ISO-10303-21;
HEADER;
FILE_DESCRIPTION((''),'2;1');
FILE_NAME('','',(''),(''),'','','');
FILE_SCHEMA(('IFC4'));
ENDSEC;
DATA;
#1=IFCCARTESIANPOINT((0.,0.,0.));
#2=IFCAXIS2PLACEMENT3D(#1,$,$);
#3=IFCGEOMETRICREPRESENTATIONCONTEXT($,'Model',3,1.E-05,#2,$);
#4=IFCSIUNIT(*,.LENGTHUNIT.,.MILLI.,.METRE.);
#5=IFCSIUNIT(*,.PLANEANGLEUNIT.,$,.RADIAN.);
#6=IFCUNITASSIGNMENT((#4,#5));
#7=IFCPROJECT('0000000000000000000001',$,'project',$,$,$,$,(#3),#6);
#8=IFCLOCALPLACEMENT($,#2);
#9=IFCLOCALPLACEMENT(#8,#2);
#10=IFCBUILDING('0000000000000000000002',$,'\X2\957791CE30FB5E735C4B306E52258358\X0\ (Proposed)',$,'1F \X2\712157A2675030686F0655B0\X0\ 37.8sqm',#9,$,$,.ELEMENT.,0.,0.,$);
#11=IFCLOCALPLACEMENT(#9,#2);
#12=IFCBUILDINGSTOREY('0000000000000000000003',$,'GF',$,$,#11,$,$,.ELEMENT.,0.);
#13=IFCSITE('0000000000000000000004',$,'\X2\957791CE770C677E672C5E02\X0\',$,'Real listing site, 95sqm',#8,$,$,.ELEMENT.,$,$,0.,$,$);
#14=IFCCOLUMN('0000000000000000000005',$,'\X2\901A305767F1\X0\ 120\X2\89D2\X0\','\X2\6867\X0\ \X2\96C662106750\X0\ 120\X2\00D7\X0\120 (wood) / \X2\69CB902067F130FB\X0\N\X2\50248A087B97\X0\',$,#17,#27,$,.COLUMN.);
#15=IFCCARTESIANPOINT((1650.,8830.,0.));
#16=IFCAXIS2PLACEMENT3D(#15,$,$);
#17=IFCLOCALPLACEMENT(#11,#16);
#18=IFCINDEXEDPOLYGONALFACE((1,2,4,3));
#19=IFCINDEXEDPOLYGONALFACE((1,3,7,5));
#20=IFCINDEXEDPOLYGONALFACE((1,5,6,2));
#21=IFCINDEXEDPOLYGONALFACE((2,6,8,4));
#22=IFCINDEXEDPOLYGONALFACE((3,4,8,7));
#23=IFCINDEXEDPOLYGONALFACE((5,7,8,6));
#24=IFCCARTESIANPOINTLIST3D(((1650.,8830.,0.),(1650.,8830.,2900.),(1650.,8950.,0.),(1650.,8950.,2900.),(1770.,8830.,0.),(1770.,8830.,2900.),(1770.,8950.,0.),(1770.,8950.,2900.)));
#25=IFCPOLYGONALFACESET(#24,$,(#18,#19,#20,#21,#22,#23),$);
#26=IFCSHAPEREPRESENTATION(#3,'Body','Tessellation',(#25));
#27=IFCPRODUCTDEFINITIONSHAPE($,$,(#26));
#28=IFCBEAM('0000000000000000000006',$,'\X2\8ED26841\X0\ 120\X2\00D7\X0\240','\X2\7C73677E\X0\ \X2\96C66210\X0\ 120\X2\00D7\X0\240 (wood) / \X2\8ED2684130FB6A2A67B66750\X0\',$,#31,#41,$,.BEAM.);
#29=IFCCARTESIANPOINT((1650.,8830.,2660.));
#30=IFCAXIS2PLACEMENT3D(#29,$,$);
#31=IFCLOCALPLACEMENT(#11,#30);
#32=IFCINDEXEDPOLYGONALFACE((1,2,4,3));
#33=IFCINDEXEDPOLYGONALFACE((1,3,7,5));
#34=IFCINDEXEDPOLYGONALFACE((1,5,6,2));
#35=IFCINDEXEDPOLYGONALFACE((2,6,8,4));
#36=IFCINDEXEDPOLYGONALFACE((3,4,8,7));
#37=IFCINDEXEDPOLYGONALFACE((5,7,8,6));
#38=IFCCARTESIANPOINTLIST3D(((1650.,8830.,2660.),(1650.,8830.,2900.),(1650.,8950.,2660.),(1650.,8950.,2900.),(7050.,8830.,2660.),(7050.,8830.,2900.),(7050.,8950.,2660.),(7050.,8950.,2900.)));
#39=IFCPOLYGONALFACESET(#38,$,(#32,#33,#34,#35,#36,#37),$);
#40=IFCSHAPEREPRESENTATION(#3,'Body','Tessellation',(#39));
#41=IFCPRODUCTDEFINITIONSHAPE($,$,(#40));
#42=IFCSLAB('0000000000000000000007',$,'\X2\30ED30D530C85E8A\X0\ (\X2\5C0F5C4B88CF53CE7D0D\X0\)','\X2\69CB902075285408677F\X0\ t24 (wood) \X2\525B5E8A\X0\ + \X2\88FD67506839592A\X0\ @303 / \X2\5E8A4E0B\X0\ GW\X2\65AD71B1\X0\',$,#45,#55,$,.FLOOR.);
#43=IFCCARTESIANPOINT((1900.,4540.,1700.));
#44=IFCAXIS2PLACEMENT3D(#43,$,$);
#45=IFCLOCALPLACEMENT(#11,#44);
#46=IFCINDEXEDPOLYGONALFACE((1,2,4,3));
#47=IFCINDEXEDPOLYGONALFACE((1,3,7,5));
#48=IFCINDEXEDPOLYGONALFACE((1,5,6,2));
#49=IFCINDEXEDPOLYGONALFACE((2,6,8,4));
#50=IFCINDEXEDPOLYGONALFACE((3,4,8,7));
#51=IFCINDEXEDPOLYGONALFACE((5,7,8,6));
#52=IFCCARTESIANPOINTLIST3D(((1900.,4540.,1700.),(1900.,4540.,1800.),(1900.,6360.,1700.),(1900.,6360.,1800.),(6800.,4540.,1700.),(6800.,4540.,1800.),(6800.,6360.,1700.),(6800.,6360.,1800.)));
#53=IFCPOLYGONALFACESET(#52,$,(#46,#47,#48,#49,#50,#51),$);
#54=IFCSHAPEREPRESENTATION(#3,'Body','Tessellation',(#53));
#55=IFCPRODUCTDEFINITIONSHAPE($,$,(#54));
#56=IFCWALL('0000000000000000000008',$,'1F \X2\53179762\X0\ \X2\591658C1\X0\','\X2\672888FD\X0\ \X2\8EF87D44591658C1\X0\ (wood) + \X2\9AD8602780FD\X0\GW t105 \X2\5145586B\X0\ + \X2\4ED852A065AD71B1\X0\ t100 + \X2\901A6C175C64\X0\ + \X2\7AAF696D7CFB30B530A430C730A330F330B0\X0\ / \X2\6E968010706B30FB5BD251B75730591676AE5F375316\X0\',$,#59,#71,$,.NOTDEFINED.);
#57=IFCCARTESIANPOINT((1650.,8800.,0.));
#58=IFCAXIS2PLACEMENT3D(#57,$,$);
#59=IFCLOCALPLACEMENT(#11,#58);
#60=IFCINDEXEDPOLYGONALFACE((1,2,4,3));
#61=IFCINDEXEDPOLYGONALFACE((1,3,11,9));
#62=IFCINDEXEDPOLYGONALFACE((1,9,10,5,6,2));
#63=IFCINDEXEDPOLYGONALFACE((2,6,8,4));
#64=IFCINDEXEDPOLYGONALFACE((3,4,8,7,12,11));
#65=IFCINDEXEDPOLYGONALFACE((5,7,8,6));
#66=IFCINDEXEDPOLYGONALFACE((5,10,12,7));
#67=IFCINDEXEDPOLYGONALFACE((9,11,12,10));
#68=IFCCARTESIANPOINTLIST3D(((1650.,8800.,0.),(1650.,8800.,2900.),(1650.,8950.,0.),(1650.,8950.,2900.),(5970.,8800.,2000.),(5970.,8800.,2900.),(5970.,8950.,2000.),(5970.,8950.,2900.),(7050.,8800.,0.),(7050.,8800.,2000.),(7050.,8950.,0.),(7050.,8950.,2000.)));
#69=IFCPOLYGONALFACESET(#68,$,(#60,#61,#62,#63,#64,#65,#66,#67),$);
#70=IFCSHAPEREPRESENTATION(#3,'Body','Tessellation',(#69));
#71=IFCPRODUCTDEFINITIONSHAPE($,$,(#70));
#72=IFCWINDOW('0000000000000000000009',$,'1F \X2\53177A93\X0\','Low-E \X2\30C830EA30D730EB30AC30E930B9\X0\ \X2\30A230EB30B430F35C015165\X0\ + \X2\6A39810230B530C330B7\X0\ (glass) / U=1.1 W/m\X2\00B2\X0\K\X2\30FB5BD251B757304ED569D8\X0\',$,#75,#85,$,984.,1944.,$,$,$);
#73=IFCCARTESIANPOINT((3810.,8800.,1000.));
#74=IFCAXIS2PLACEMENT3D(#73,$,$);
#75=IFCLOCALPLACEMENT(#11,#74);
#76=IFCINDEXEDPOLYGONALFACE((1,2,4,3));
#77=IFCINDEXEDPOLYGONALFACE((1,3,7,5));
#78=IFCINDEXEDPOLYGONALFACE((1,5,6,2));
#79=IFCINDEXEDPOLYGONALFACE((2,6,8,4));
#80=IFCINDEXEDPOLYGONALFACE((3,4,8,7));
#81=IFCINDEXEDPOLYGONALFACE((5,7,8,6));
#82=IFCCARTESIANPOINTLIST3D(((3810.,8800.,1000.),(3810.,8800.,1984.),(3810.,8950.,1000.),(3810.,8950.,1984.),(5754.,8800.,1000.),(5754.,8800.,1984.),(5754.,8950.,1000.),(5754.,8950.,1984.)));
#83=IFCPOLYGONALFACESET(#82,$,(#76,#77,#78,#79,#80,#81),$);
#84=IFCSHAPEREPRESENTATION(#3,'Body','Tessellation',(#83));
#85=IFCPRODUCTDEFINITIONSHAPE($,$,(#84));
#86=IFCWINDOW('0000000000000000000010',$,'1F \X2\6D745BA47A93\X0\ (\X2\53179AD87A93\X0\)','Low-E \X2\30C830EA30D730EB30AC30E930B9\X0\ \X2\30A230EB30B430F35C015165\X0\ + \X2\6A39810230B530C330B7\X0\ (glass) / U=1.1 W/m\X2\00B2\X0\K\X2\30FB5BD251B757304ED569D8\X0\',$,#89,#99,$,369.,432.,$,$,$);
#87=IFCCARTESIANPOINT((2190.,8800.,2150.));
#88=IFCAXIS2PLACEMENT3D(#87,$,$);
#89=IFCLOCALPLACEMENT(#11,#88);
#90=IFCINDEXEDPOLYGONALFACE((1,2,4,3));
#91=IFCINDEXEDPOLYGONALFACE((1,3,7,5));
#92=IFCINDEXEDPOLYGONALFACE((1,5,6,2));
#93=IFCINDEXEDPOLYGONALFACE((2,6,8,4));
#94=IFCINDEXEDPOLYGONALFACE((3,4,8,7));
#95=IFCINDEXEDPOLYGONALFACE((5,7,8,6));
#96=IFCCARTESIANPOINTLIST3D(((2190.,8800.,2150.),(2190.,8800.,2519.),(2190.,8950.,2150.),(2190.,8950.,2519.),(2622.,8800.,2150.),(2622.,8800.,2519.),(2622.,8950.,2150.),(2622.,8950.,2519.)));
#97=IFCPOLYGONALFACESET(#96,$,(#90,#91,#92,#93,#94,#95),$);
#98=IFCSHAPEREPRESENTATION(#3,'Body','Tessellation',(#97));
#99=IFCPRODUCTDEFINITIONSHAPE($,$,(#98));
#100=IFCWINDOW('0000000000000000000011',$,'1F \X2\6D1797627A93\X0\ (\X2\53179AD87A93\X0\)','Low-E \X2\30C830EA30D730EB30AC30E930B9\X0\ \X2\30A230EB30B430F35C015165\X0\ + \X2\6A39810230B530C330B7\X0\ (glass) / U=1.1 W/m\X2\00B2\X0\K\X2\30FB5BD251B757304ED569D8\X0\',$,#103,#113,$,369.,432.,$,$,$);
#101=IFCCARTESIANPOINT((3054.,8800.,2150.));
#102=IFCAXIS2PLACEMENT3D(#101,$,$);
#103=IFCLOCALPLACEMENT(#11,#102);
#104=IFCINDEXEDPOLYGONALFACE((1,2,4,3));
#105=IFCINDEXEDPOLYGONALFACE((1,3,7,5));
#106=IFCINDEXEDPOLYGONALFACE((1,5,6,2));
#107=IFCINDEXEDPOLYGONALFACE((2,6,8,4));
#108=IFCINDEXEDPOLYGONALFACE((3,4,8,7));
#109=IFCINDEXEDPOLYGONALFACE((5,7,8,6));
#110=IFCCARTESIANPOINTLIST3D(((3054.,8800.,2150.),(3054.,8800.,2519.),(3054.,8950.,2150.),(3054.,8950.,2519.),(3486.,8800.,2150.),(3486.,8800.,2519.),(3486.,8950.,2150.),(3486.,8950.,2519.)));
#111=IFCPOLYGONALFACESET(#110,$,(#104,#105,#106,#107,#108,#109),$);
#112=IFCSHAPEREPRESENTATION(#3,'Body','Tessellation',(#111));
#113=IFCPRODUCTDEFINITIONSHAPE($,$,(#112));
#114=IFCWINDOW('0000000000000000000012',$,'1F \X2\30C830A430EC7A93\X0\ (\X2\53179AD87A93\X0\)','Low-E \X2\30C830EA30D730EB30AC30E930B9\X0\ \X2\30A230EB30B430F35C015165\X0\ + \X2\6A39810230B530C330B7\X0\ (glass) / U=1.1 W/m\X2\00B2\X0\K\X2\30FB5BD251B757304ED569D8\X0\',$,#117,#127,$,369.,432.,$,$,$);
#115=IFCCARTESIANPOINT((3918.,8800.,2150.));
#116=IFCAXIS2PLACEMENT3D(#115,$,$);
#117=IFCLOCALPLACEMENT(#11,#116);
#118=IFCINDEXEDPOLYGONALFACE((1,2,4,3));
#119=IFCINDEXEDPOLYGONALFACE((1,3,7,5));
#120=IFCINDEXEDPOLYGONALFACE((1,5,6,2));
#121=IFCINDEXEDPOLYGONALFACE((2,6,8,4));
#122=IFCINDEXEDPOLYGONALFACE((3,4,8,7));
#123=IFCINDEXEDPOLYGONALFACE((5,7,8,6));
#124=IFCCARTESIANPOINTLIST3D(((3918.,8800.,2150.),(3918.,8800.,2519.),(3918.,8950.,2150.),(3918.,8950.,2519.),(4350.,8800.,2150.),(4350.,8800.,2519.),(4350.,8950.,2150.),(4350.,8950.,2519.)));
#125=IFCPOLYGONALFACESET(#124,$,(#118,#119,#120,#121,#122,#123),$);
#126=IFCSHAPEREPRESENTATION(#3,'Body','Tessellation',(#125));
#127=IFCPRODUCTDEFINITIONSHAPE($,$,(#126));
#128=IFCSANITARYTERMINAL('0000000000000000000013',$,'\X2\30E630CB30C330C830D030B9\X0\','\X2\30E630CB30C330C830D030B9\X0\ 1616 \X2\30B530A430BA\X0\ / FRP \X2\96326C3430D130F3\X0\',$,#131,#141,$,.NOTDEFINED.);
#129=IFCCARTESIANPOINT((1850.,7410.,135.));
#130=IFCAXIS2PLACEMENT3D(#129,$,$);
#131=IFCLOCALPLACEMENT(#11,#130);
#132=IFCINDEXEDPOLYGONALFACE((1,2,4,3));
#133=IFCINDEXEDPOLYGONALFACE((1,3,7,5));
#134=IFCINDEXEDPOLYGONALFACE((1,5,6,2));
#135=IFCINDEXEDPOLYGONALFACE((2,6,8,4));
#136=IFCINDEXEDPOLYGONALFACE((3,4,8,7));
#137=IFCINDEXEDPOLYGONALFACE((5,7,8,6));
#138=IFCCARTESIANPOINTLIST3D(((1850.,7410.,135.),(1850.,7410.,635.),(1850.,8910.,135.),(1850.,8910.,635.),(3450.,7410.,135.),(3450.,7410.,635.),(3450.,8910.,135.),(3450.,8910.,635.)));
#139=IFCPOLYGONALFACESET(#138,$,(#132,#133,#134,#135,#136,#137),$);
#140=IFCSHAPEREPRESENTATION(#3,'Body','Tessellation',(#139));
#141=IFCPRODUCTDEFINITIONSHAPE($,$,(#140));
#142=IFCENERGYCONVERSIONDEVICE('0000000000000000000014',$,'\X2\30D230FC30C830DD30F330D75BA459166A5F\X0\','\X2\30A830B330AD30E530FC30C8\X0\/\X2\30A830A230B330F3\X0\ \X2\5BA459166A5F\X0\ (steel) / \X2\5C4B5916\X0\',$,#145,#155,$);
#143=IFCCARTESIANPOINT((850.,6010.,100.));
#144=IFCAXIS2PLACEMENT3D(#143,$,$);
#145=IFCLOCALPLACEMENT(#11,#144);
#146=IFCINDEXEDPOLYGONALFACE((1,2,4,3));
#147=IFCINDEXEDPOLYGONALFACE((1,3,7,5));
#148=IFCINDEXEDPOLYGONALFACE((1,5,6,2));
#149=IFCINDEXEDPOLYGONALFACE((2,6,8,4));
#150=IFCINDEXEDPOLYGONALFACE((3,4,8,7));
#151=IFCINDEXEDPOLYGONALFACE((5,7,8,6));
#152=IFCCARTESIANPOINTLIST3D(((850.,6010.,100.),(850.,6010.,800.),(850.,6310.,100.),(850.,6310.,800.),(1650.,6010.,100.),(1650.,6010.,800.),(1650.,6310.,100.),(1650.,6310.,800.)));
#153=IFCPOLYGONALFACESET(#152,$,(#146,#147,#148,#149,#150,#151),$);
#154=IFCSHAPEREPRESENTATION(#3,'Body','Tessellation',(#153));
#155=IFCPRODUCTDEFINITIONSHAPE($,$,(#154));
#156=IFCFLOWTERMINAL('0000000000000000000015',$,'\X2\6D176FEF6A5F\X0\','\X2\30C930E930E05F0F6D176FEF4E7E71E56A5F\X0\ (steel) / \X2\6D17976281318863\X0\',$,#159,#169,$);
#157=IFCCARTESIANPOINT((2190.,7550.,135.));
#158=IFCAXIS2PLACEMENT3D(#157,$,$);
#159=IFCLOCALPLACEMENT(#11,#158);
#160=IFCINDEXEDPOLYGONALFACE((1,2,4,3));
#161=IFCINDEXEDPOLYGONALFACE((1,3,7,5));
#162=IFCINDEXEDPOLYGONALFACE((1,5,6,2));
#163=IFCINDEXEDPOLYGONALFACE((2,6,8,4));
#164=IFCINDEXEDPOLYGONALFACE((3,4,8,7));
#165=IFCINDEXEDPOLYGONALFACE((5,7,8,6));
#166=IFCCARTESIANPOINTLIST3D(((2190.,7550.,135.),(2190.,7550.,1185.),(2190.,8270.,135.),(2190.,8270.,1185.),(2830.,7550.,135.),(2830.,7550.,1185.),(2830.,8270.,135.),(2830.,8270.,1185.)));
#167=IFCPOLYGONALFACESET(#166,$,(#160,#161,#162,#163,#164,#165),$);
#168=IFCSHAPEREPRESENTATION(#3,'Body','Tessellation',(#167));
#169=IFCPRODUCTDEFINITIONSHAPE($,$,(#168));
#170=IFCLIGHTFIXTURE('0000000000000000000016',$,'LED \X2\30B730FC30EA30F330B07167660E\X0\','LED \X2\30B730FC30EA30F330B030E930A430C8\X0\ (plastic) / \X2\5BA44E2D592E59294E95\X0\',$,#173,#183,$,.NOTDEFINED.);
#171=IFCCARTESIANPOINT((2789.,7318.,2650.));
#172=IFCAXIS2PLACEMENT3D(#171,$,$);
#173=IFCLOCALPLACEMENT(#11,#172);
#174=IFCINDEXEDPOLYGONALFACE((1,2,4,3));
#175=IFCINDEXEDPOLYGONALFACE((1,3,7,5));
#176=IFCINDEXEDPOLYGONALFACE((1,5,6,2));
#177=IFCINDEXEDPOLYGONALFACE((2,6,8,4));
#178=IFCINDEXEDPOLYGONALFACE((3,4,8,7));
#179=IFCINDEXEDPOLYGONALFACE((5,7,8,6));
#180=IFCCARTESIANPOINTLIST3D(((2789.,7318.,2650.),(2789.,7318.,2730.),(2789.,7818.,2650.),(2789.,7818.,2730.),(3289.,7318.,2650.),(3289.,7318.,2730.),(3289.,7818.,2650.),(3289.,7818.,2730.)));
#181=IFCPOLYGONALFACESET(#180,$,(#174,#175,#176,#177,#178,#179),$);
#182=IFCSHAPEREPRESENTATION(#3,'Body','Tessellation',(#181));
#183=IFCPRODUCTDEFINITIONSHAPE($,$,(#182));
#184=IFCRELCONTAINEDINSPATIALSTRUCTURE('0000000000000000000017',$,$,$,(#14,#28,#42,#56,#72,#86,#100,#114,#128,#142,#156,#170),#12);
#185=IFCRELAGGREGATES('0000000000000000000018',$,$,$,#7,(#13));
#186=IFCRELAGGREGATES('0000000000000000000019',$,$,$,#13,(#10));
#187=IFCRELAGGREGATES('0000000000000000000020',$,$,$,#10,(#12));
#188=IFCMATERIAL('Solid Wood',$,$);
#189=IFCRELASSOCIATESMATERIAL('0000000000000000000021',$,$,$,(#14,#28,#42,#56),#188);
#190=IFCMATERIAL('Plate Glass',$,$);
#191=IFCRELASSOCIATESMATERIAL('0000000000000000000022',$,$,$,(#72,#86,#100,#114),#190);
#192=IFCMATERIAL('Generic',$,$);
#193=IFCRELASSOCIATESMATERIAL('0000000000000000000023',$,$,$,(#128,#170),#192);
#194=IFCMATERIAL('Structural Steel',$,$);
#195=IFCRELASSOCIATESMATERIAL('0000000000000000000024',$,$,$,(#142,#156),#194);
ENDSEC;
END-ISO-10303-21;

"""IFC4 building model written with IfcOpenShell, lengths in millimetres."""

from ifc_helpers import new_model, si_unit, frame, frame_2d, origin, place, context, project, spatial, rectangle, extrude, material, element, fill, save


model = new_model("IFC4")

# Units and contexts
model_context = context("Model", 3, precision=1e-05, world=origin())
ifc_project = project(units=[si_unit("LENGTHUNIT", "METRE", prefix="MILLI"), si_unit("PLANEANGLEUNIT", "RADIAN")], contexts=[model_context])

# Site, building, storey
site_placement = place(None, origin())
site = spatial("IfcSite", under=ifc_project, at=site_placement, Name="長野県松本市", ObjectType="Real listing site, 95sqm", CompositionType="ELEMENT", RefElevation=0.0)
building_placement = place(site_placement, origin())
building = spatial("IfcBuilding", under=site, at=building_placement, Name="長野・平屋の別荘 (Proposed)", ObjectType="1F 無垢材と漆喰 37.8sqm", CompositionType="ELEMENT", ElevationOfRefHeight=0.0, ElevationOfTerrain=0.0)
storey_placement = place(building_placement, origin())
storey = spatial("IfcBuildingStorey", under=building, at=storey_placement, Name="GF", CompositionType="ELEMENT", Elevation=0.0)

# Column
ifc_material_1 = material(Name="Solid Wood")
column_1_placement = place(storey_placement, frame((1650.0, 8830.0, 0.0)))
element("IfcColumn", 1, at=column_1_placement, inside=storey, material=ifc_material_1, Name="通し柱 120角", Description="桧 集成材 120×120 (wood) / 構造柱・N値計算", PredefinedType="COLUMN", context=model_context, shape_type="SweptSolid", body=[
    extrude(rectangle(XDim=120.0, YDim=120.0, at=frame_2d((60.0, 60.0))), frame((1650.0, 8830.0, 0.0)), (0.0, 0.0, 1.0), 2900.0),
])

# Beam
beam_1_placement = place(storey_placement, frame((1650.0, 8830.0, 2660.0)))
element("IfcBeam", 2, at=beam_1_placement, inside=storey, material=ifc_material_1, Name="軒桁 120×240", Description="米松 集成 120×240 (wood) / 軒桁・横架材", PredefinedType="BEAM", context=model_context, shape_type="SweptSolid", body=[
    extrude(rectangle(XDim=5400.0, YDim=120.0, at=frame_2d((2700.0, 60.0))), frame((1650.0, 8830.0, 2660.0)), (0.0, 0.0, 1.0), 240.0),
])

# Slab
slab_placement = place(storey_placement, frame((1900.0, 4540.0, 1700.0)))
element("IfcSlab", 3, at=slab_placement, inside=storey, material=ifc_material_1, Name="ロフト床 (小屋裏収納)", Description="構造用合板 t24 (wood) 剛床 + 製材根太 @303 / 床下 GW断熱", PredefinedType="FLOOR", context=model_context, shape_type="SweptSolid", body=[
    extrude(rectangle(XDim=4900.0, YDim=1820.0, at=frame_2d((2450.0, 910.0))), frame((1900.0, 4540.0, 1700.0)), (0.0, 0.0, 1.0), 100.0),
])

# Wall, openings, windows
wall_1_placement = place(storey_placement, frame((1650.0, 8800.0, 0.0)))
wall_1 = element("IfcWall", 4, at=wall_1_placement, inside=storey, material=ifc_material_1, Name="1F 北面 外壁", Description="木製 軸組外壁 (wood) + 高性能GW t105 充填 + 付加断熱 t100 + 通気層 + 窯業系サイディング / 準耐火・寒冷地外皮強化", PredefinedType="NOTDEFINED", context=model_context, shape_type="SweptSolid", body=[
    extrude(rectangle(XDim=5400.0, YDim=150.0, at=frame_2d((2700.0, 75.0))), frame((1650.0, 8800.0, 0.0)), (0.0, 0.0, 1.0), 2900.0),
])
opening_1_placement = place(storey_placement, frame((3810.0, 8800.0, 1000.0)))
opening_1 = element("IfcOpeningElement", 5, at=opening_1_placement, cuts=wall_1, PredefinedType="NOTDEFINED", context=model_context, shape_type="SweptSolid", body=[
    extrude(rectangle(XDim=1944.0, YDim=150.0, at=frame_2d((972.0, 75.0))), frame((3810.0, 8800.0, 1000.0)), (0.0, 0.0, 1.0), 984.0),
])
opening_2_placement = place(storey_placement, frame((2190.0, 8800.0, 2150.0)))
opening_2 = element("IfcOpeningElement", 6, at=opening_2_placement, cuts=wall_1, PredefinedType="NOTDEFINED", context=model_context, shape_type="SweptSolid", body=[
    extrude(rectangle(XDim=432.0, YDim=150.0, at=frame_2d((216.0, 75.0))), frame((2190.0, 8800.0, 2150.0)), (0.0, 0.0, 1.0), 369.0),
])
opening_3_placement = place(storey_placement, frame((3054.0, 8800.0, 2150.0)))
opening_3 = element("IfcOpeningElement", 7, at=opening_3_placement, cuts=wall_1, PredefinedType="NOTDEFINED", context=model_context, shape_type="SweptSolid", body=[
    extrude(rectangle(XDim=432.0, YDim=150.0, at=frame_2d((216.0, 75.0))), frame((3054.0, 8800.0, 2150.0)), (0.0, 0.0, 1.0), 369.0),
])
opening_4_placement = place(storey_placement, frame((3918.0, 8800.0, 2150.0)))
opening_4 = element("IfcOpeningElement", 8, at=opening_4_placement, cuts=wall_1, PredefinedType="NOTDEFINED", context=model_context, shape_type="SweptSolid", body=[
    extrude(rectangle(XDim=432.0, YDim=150.0, at=frame_2d((216.0, 75.0))), frame((3918.0, 8800.0, 2150.0)), (0.0, 0.0, 1.0), 369.0),
])
ifc_material_2 = material(Name="Plate Glass")
window_1_placement = place(storey_placement, frame((3810.0, 8800.0, 1000.0)))
window_1 = element("IfcWindow", 9, at=window_1_placement, inside=storey, material=ifc_material_2, Name="1F 北窓", Description="Low-E トリプルガラス アルゴン封入 + 樹脂サッシ (glass) / U=1.1 W/m²K・寒冷地仕様", OverallHeight=984.0, OverallWidth=1944.0, context=model_context, shape_type="SweptSolid", body=[
    extrude(rectangle(XDim=1944.0, YDim=150.0, at=frame_2d((972.0, 75.0))), frame((3810.0, 8800.0, 1000.0)), (0.0, 0.0, 1.0), 984.0),
])
fill(opening_1, window_1)
window_2_placement = place(storey_placement, frame((2190.0, 8800.0, 2150.0)))
window_2 = element("IfcWindow", 10, at=window_2_placement, inside=storey, material=ifc_material_2, Name="1F 浴室窓 (北高窓)", Description="Low-E トリプルガラス アルゴン封入 + 樹脂サッシ (glass) / U=1.1 W/m²K・寒冷地仕様", OverallHeight=369.0, OverallWidth=432.0, context=model_context, shape_type="SweptSolid", body=[
    extrude(rectangle(XDim=432.0, YDim=150.0, at=frame_2d((216.0, 75.0))), frame((2190.0, 8800.0, 2150.0)), (0.0, 0.0, 1.0), 369.0),
])
fill(opening_2, window_2)
window_3_placement = place(storey_placement, frame((3054.0, 8800.0, 2150.0)))
window_3 = element("IfcWindow", 11, at=window_3_placement, inside=storey, material=ifc_material_2, Name="1F 洗面窓 (北高窓)", Description="Low-E トリプルガラス アルゴン封入 + 樹脂サッシ (glass) / U=1.1 W/m²K・寒冷地仕様", OverallHeight=369.0, OverallWidth=432.0, context=model_context, shape_type="SweptSolid", body=[
    extrude(rectangle(XDim=432.0, YDim=150.0, at=frame_2d((216.0, 75.0))), frame((3054.0, 8800.0, 2150.0)), (0.0, 0.0, 1.0), 369.0),
])
fill(opening_3, window_3)
window_4_placement = place(storey_placement, frame((3918.0, 8800.0, 2150.0)))
window_4 = element("IfcWindow", 12, at=window_4_placement, inside=storey, material=ifc_material_2, Name="1F トイレ窓 (北高窓)", Description="Low-E トリプルガラス アルゴン封入 + 樹脂サッシ (glass) / U=1.1 W/m²K・寒冷地仕様", OverallHeight=369.0, OverallWidth=432.0, context=model_context, shape_type="SweptSolid", body=[
    extrude(rectangle(XDim=432.0, YDim=150.0, at=frame_2d((216.0, 75.0))), frame((3918.0, 8800.0, 2150.0)), (0.0, 0.0, 1.0), 369.0),
])
fill(opening_4, window_4)

# Sanitary terminal
ifc_material_3 = material(Name="Generic")
sanitary_terminal_placement = place(storey_placement, frame((1850.0, 7410.0, 135.0)))
element("IfcSanitaryTerminal", 13, at=sanitary_terminal_placement, inside=storey, material=ifc_material_3, Name="ユニットバス", Description="ユニットバス 1616 サイズ / FRP 防水パン", PredefinedType="NOTDEFINED", context=model_context, shape_type="SweptSolid", body=[
    extrude(rectangle(XDim=1600.0, YDim=1500.0, at=frame_2d((800.0, 750.0))), frame((1850.0, 7410.0, 135.0)), (0.0, 0.0, 1.0), 500.0),
])

# Shared definitions
ifc_material_4 = material(Name="Structural Steel")

# Energy conversion device
energy_conversion_device_placement = place(storey_placement, frame((850.0, 6010.0, 100.0)))
element("IfcEnergyConversionDevice", 14, at=energy_conversion_device_placement, inside=storey, material=ifc_material_4, Name="ヒートポンプ室外機", Description="エコキュート/エアコン 室外機 (steel) / 屋外", context=model_context, shape_type="SweptSolid", body=[
    extrude(rectangle(XDim=800.0, YDim=300.0, at=frame_2d((400.0, 150.0))), frame((850.0, 6010.0, 100.0)), (0.0, 0.0, 1.0), 700.0),
])

# Flow terminal
flow_terminal_placement = place(storey_placement, frame((2190.0, 7550.0, 135.0)))
element("IfcFlowTerminal", 15, at=flow_terminal_placement, inside=storey, material=ifc_material_4, Name="洗濯機", Description="ドラム式洗濯乾燥機 (steel) / 洗面脱衣", context=model_context, shape_type="SweptSolid", body=[
    extrude(rectangle(XDim=640.0, YDim=720.0, at=frame_2d((320.0, 360.0))), frame((2190.0, 7550.0, 135.0)), (0.0, 0.0, 1.0), 1050.0),
])

# Light fixture
light_fixture_placement = place(storey_placement, frame((2789.0, 7318.0, 2650.0)))
element("IfcLightFixture", 16, at=light_fixture_placement, inside=storey, material=ifc_material_3, Name="LED シーリング照明", Description="LED シーリングライト (plastic) / 室中央天井", PredefinedType="NOTDEFINED", context=model_context, shape_type="SweptSolid", body=[
    extrude(rectangle(XDim=500.0, YDim=500.0, at=frame_2d((250.0, 250.0))), frame((2789.0, 7318.0, 2650.0)), (0.0, 0.0, 1.0), 80.0),
])

save(model, "model.ifc")
